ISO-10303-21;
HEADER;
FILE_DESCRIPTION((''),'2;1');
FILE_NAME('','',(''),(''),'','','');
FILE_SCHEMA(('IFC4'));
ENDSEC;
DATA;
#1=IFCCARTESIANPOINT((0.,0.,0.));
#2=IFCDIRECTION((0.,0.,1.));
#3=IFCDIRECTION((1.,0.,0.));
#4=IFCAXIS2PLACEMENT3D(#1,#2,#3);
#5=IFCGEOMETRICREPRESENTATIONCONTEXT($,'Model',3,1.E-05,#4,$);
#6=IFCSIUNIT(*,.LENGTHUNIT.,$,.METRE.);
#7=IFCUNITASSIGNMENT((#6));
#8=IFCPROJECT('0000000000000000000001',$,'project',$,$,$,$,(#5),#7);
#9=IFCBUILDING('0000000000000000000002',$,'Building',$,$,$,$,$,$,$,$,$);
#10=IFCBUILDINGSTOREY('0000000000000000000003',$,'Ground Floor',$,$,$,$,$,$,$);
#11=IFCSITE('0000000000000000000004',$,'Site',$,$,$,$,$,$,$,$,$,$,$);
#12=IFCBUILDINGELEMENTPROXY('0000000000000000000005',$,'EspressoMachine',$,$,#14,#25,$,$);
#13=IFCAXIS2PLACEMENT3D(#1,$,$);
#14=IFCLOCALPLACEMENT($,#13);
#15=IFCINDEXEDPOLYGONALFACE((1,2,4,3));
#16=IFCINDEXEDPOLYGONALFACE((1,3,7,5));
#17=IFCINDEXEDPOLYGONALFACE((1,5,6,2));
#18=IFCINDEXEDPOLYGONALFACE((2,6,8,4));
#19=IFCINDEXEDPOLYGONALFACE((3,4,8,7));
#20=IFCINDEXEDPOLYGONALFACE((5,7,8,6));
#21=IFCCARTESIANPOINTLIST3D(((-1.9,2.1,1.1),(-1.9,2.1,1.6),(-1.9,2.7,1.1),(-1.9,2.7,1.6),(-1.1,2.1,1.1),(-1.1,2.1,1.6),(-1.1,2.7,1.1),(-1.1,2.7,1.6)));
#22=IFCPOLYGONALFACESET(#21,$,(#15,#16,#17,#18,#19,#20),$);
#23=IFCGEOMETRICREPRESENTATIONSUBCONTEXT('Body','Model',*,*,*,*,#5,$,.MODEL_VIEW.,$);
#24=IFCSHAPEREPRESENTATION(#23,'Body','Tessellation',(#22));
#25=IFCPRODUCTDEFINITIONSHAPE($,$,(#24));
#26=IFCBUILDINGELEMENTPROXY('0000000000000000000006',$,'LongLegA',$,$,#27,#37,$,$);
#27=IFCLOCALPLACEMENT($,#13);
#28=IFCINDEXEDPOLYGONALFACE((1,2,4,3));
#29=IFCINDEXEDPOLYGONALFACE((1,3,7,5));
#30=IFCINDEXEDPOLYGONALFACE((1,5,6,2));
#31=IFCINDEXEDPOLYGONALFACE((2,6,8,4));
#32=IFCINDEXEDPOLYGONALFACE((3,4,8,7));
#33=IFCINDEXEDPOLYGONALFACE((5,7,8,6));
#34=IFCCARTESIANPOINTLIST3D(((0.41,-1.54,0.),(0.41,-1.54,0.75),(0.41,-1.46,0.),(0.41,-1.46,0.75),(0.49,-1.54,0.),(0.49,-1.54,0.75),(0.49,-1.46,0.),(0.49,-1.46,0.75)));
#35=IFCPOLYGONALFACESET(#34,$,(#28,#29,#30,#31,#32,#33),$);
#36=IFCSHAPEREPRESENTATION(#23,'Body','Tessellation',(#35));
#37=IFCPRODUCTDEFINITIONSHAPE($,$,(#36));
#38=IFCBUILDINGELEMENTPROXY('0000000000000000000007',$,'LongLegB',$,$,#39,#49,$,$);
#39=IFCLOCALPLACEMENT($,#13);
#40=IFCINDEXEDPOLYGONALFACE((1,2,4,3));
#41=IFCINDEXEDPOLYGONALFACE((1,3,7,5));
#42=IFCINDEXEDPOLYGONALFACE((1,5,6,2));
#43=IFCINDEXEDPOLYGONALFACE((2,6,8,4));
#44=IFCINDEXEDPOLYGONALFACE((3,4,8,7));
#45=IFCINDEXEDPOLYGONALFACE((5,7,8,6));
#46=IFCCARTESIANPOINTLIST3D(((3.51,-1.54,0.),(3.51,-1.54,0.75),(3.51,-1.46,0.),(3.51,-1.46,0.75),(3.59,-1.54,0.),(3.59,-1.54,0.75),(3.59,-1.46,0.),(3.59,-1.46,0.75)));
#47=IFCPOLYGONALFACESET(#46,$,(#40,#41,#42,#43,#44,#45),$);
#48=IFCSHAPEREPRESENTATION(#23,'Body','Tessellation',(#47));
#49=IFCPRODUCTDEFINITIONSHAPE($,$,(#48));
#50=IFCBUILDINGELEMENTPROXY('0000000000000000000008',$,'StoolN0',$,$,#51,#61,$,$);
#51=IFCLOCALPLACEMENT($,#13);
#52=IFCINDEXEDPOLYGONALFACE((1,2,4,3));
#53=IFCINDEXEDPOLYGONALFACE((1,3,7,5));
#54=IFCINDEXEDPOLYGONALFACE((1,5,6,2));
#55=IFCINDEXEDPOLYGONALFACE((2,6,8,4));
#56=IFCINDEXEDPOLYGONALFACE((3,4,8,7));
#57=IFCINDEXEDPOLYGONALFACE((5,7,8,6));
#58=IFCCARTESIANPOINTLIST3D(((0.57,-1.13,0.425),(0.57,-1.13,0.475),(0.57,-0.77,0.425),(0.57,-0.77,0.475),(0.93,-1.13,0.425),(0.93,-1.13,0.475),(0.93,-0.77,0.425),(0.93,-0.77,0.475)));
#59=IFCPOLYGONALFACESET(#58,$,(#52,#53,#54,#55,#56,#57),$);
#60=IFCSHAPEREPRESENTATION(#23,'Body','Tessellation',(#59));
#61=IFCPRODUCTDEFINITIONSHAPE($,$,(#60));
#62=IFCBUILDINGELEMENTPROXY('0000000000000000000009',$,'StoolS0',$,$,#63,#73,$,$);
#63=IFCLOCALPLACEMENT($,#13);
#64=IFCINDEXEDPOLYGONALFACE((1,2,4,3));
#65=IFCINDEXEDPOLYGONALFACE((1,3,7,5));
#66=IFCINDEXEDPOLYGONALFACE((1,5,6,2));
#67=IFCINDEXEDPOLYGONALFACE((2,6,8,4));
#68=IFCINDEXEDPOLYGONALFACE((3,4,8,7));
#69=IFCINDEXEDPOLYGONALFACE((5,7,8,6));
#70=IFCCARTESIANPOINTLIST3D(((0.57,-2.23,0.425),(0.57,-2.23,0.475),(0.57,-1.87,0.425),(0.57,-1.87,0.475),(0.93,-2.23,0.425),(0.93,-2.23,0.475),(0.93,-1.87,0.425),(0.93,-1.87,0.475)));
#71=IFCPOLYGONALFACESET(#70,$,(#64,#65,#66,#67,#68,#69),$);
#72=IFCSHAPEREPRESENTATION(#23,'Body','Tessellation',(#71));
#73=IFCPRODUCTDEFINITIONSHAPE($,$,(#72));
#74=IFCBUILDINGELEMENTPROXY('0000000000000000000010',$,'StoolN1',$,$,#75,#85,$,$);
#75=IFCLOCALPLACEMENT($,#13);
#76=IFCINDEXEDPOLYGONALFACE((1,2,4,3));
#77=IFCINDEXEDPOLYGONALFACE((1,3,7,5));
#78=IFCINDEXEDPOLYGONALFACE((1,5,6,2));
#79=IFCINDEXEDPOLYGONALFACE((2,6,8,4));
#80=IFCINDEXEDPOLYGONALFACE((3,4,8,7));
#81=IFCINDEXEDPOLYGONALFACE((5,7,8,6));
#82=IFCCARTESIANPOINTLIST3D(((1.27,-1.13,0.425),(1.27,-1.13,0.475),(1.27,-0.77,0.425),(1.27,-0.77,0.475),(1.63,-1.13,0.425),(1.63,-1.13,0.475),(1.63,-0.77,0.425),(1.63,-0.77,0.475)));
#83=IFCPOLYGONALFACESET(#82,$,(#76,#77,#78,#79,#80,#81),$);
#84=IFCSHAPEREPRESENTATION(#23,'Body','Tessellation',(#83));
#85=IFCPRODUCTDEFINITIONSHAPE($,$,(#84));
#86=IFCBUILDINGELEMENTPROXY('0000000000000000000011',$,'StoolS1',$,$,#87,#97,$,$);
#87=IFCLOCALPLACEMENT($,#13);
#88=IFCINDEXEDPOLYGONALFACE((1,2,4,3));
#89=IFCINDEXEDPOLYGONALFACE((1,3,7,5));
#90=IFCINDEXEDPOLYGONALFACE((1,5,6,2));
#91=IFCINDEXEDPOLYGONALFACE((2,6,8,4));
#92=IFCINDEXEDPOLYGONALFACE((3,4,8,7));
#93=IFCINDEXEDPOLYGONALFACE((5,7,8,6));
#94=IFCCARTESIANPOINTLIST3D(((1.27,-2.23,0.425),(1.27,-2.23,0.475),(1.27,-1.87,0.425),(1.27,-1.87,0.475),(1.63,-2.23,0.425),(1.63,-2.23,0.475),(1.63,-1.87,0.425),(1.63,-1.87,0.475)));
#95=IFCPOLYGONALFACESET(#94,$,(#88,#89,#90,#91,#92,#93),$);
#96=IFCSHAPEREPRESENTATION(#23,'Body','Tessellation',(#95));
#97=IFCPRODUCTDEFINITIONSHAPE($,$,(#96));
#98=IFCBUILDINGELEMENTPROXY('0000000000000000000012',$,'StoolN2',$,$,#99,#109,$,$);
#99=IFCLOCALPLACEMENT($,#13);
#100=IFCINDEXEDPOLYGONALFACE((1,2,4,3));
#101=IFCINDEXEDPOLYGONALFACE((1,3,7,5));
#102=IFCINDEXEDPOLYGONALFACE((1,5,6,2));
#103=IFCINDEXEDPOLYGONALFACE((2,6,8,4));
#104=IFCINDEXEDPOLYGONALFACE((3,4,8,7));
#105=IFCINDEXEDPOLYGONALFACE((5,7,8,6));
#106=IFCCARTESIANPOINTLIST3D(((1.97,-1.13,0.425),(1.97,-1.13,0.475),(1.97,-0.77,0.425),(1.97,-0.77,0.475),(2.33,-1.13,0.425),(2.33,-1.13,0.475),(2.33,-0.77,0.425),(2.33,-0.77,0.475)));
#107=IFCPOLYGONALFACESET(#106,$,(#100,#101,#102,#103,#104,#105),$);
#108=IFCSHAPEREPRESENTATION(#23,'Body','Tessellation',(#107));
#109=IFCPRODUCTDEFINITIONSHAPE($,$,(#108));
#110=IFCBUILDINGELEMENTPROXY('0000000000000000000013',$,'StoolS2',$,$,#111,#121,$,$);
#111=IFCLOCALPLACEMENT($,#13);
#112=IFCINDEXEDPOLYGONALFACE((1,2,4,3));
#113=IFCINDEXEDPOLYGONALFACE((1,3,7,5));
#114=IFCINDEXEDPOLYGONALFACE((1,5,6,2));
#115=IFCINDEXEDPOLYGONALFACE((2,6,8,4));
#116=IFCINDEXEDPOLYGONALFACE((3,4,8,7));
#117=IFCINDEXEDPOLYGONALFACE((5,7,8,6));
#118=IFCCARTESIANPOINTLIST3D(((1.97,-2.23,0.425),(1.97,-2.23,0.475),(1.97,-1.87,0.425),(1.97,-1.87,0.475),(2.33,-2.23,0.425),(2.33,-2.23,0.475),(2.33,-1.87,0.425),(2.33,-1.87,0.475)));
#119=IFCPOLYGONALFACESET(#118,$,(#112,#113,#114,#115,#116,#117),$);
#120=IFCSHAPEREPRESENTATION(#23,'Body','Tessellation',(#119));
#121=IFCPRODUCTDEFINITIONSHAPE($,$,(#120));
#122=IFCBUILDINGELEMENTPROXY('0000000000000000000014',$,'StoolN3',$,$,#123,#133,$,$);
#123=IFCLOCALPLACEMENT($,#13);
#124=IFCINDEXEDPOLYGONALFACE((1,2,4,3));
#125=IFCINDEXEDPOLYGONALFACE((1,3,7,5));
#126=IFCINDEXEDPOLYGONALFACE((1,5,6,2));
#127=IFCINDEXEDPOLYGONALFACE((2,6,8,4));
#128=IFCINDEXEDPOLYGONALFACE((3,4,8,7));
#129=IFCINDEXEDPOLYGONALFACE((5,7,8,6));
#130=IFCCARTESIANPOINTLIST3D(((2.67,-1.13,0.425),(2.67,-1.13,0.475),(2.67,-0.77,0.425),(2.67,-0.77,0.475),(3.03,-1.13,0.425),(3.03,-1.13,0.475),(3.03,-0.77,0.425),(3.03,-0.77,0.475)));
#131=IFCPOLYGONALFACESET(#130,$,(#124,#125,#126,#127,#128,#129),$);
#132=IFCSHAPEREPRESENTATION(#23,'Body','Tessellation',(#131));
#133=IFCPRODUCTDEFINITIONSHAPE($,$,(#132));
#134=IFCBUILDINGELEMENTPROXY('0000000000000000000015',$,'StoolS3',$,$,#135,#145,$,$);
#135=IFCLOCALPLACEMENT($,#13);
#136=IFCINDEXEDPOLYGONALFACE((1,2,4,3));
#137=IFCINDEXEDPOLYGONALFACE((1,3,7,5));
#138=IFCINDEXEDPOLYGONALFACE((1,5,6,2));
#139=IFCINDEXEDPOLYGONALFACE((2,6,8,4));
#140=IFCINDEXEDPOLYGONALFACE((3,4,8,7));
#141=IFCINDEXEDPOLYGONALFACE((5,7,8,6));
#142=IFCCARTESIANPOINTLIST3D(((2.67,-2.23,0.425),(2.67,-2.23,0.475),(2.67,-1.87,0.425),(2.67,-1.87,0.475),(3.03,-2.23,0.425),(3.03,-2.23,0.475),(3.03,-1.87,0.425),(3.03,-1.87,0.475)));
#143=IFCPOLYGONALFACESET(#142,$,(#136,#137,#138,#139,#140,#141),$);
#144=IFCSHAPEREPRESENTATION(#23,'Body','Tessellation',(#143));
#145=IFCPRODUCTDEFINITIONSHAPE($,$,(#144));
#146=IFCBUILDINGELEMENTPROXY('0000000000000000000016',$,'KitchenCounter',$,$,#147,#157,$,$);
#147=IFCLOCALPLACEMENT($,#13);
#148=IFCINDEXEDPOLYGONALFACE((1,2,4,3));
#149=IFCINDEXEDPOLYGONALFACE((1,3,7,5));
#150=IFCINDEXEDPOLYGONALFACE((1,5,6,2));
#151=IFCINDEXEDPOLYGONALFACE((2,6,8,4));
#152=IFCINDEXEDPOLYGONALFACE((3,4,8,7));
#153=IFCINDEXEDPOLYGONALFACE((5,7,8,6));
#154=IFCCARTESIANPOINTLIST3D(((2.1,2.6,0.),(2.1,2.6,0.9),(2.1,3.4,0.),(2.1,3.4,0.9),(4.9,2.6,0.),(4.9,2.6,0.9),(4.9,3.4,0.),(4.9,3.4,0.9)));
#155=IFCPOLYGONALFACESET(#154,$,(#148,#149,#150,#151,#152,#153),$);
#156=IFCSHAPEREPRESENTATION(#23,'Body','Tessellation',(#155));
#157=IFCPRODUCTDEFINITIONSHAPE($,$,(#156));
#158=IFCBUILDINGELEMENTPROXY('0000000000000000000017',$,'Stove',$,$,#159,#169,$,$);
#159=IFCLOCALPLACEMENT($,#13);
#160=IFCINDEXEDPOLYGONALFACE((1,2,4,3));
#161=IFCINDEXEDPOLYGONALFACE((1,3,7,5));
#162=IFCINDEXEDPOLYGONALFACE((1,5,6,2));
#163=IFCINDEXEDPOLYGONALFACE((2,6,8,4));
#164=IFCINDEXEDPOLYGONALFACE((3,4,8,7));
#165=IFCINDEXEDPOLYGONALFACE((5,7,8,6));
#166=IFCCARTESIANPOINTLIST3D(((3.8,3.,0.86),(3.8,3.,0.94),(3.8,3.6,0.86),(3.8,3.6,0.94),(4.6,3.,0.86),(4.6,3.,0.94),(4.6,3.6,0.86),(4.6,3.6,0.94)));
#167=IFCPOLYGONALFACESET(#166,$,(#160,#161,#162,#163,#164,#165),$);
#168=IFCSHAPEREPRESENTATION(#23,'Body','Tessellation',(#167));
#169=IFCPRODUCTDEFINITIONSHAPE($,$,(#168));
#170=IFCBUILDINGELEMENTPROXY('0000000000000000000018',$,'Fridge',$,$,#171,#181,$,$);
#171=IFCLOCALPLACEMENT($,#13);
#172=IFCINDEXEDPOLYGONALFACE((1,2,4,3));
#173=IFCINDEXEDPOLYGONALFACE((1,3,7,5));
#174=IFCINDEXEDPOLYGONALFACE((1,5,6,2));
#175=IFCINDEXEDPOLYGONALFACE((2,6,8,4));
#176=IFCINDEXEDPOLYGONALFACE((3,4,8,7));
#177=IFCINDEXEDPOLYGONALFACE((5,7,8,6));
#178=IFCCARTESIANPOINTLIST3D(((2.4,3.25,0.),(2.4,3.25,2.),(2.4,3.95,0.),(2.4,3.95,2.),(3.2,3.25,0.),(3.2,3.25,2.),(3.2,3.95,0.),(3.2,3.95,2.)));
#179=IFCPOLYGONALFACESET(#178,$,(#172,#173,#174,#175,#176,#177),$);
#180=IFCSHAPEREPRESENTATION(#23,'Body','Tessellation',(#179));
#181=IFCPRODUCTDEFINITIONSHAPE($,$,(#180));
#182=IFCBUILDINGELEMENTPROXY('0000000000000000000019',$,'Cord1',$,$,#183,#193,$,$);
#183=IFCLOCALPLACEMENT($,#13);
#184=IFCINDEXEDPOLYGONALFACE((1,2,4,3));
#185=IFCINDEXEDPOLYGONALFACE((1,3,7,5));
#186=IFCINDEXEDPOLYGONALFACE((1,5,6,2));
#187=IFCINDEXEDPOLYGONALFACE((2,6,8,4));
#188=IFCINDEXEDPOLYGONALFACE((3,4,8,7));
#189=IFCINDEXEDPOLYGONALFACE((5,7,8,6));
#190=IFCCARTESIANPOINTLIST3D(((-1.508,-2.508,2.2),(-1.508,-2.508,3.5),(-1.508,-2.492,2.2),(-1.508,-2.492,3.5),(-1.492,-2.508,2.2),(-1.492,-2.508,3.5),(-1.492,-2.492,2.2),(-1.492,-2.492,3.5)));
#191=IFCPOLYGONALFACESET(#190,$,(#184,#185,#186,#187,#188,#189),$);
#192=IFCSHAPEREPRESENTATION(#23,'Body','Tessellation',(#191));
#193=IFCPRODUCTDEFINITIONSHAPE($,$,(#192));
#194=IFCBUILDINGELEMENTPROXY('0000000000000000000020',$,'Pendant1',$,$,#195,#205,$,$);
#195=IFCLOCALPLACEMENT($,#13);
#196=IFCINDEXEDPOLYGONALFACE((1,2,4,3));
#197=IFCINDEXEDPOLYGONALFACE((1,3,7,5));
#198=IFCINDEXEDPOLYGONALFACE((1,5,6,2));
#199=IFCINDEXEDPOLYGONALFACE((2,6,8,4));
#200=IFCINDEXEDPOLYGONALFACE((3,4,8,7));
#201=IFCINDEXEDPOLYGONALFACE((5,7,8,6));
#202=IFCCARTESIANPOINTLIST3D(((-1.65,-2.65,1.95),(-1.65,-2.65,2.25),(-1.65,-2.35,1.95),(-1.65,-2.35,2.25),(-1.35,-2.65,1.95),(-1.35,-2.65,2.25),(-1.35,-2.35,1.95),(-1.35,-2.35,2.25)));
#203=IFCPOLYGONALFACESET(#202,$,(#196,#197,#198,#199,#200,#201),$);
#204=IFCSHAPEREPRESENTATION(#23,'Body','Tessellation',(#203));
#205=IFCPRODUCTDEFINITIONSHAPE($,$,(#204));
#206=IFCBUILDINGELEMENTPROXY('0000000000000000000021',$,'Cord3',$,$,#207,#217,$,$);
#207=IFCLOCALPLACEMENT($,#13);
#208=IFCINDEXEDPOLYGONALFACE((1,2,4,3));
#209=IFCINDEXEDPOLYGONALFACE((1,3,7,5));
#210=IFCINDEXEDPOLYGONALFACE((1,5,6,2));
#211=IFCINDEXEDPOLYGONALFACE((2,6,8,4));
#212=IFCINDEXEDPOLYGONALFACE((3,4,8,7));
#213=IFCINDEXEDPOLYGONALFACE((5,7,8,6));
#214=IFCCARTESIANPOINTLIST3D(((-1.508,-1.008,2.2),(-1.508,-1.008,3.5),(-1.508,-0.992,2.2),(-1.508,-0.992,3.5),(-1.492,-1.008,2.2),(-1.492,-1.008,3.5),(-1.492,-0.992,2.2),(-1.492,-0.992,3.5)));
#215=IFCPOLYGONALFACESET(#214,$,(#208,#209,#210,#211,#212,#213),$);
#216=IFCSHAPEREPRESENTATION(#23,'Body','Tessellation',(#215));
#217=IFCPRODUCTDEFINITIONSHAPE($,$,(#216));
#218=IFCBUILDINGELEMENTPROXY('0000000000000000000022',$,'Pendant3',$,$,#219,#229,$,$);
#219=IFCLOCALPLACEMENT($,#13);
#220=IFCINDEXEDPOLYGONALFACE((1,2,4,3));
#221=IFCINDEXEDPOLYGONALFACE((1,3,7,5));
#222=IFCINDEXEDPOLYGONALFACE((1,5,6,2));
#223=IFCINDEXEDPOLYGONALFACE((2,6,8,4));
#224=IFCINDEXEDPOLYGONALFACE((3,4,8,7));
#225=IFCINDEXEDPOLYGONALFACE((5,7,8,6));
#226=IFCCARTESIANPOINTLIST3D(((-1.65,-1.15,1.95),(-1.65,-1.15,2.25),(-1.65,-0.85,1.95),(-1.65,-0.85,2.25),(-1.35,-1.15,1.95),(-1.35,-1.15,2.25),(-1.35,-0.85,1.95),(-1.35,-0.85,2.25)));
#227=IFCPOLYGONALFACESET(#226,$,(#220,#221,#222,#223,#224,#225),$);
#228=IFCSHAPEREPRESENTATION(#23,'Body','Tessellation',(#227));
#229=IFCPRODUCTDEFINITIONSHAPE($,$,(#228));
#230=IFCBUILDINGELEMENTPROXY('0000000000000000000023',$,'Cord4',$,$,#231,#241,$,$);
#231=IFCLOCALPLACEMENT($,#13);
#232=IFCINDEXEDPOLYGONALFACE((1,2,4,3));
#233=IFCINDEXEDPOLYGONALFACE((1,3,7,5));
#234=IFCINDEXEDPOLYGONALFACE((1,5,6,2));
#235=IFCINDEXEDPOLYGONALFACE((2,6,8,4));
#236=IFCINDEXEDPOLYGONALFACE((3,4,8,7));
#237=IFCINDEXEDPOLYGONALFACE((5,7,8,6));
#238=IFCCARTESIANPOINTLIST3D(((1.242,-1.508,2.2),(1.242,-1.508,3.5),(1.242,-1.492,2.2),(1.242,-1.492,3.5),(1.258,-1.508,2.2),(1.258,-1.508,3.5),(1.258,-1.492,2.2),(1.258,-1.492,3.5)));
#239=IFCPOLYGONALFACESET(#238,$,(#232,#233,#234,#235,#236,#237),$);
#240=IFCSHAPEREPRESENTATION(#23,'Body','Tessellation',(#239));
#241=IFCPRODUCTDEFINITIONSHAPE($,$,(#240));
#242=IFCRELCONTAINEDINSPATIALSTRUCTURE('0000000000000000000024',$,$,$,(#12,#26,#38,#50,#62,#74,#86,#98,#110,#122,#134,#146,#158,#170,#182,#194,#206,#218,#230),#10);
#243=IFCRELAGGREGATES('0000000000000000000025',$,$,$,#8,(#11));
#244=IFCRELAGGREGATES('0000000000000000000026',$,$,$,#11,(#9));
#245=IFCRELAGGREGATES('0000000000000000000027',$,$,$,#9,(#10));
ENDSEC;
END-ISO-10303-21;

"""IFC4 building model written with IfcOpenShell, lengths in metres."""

from ifc_helpers import new_model, si_unit, frame, origin_with_axes, origin_2d, place, context, subcontext, project, spatial, rectangle, extrude, element, save


model = new_model("IFC4")

# Units and contexts
model_context = context("Model", 3, precision=1e-05, world=origin_with_axes())
body_context = subcontext(model_context, "Body", "Model", "MODEL_VIEW")
ifc_project = project(units=[si_unit("LENGTHUNIT", "METRE")], contexts=[model_context])

# Site, building, storey
site = spatial("IfcSite", under=ifc_project, Name="Site")
building = spatial("IfcBuilding", under=site, Name="Building")
storey = spatial("IfcBuildingStorey", under=building, Name="Ground Floor")

# Building element proxies
proxy_1_placement = place(None, frame((-1.5, 2.4, 1.35), z_axis=(0.0, 0.0, 1.0), x_axis=(1.0, 0.0, 0.0)))
element("IfcBuildingElementProxy", 1, at=proxy_1_placement, inside=storey, Name="EspressoMachine", context=body_context, shape_type="SweptSolid", body=[
    extrude(rectangle(XDim=0.8, YDim=0.6, at=origin_2d()), frame((0.0, 0.0, -0.25)), (0.0, 0.0, 1.0), 0.5),
])
for number, where, z_axis, x_axis, name in (
    (2, (0.45, -1.5, 0.375), (0.0, 0.0, 1.0), (1.0, 0.0, 0.0), "LongLegA"),
    (3, (3.55, -1.5, 0.375), (0.0, 0.0, 1.0), (1.0, 0.0, 0.0), "LongLegB"),
):
    element("IfcBuildingElementProxy", number, at=place(None, frame(where, z_axis=z_axis, x_axis=x_axis)), inside=storey, Name=name, context=body_context, shape_type="SweptSolid", body=[
        extrude(rectangle(XDim=0.08, YDim=0.08, at=origin_2d()), frame((0.0, 0.0, -0.375)), (0.0, 0.0, 1.0), 0.75),
    ])
for number, where, z_axis, x_axis, name in (
    (4, (0.75, -0.95, 0.45), (0.0, 0.0, 1.0), (1.0, 0.0, 0.0), "StoolN0"),
    (5, (0.75, -2.05, 0.45), (0.0, 0.0, 1.0), (1.0, 0.0, 0.0), "StoolS0"),
    (6, (1.45, -0.95, 0.45), (0.0, 0.0, 1.0), (1.0, 0.0, 0.0), "StoolN1"),
    (7, (1.45, -2.05, 0.45), (0.0, 0.0, 1.0), (1.0, 0.0, 0.0), "StoolS1"),
    (8, (2.15, -0.95, 0.45), (0.0, 0.0, 1.0), (1.0, 0.0, 0.0), "StoolN2"),
    (9, (2.15, -2.05, 0.45), (0.0, 0.0, 1.0), (1.0, 0.0, 0.0), "StoolS2"),
    (10, (2.85, -0.95, 0.45), (0.0, 0.0, 1.0), (1.0, 0.0, 0.0), "StoolN3"),
    (11, (2.85, -2.05, 0.45), (0.0, 0.0, 1.0), (1.0, 0.0, 0.0), "StoolS3"),
):
    element("IfcBuildingElementProxy", number, at=place(None, frame(where, z_axis=z_axis, x_axis=x_axis)), inside=storey, Name=name, context=body_context, shape_type="SweptSolid", body=[
        extrude(rectangle(XDim=0.36, YDim=0.36, at=origin_2d()), frame((0.0, 0.0, -0.025)), (0.0, 0.0, 1.0), 0.05),
    ])
proxy_2_placement = place(None, frame((3.5, 3.0, 0.45), z_axis=(0.0, 0.0, 1.0), x_axis=(1.0, 0.0, 0.0)))
element("IfcBuildingElementProxy", 12, at=proxy_2_placement, inside=storey, Name="KitchenCounter", context=body_context, shape_type="SweptSolid", body=[
    extrude(rectangle(XDim=2.8, YDim=0.8, at=origin_2d()), frame((0.0, 0.0, -0.45)), (0.0, 0.0, 1.0), 0.9),
])
proxy_3_placement = place(None, frame((4.2, 3.3, 0.9), z_axis=(0.0, 0.0, 1.0), x_axis=(1.0, 0.0, 0.0)))
element("IfcBuildingElementProxy", 13, at=proxy_3_placement, inside=storey, Name="Stove", context=body_context, shape_type="SweptSolid", body=[
    extrude(rectangle(XDim=0.8, YDim=0.6, at=origin_2d()), frame((0.0, 0.0, -0.04)), (0.0, 0.0, 1.0), 0.08),
])
proxy_4_placement = place(None, frame((2.8, 3.6, 1.0), z_axis=(0.0, 0.0, 1.0), x_axis=(1.0, 0.0, 0.0)))
element("IfcBuildingElementProxy", 14, at=proxy_4_placement, inside=storey, Name="Fridge", context=body_context, shape_type="SweptSolid", body=[
    extrude(rectangle(XDim=0.8, YDim=0.7, at=origin_2d()), frame((0.0, 0.0, -1.0)), (0.0, 0.0, 1.0), 2.0),
])
proxy_5_placement = place(None, frame((-1.5, -2.5, 2.85), z_axis=(0.0, 0.0, 1.0), x_axis=(1.0, 0.0, 0.0)))
element("IfcBuildingElementProxy", 15, at=proxy_5_placement, inside=storey, Name="Cord1", context=body_context, shape_type="SweptSolid", body=[
    extrude(rectangle(XDim=0.016, YDim=0.016, at=origin_2d()), frame((0.0, 0.0, -0.65)), (0.0, 0.0, 1.0), 1.3),
])
proxy_6_placement = place(None, frame((-1.5, -2.5, 2.1), z_axis=(0.0, 0.0, 1.0), x_axis=(1.0, 0.0, 0.0)))
element("IfcBuildingElementProxy", 16, at=proxy_6_placement, inside=storey, Name="Pendant1", context=body_context, shape_type="SweptSolid", body=[
    extrude(rectangle(XDim=0.3, YDim=0.3, at=origin_2d()), frame((0.0, 0.0, -0.15)), (0.0, 0.0, 1.0), 0.3),
])
proxy_7_placement = place(None, frame((-1.5, -1.0, 2.85), z_axis=(0.0, 0.0, 1.0), x_axis=(1.0, 0.0, 0.0)))
element("IfcBuildingElementProxy", 17, at=proxy_7_placement, inside=storey, Name="Cord3", context=body_context, shape_type="SweptSolid", body=[
    extrude(rectangle(XDim=0.016, YDim=0.016, at=origin_2d()), frame((0.0, 0.0, -0.65)), (0.0, 0.0, 1.0), 1.3),
])
proxy_8_placement = place(None, frame((-1.5, -1.0, 2.1), z_axis=(0.0, 0.0, 1.0), x_axis=(1.0, 0.0, 0.0)))
element("IfcBuildingElementProxy", 18, at=proxy_8_placement, inside=storey, Name="Pendant3", context=body_context, shape_type="SweptSolid", body=[
    extrude(rectangle(XDim=0.3, YDim=0.3, at=origin_2d()), frame((0.0, 0.0, -0.15)), (0.0, 0.0, 1.0), 0.3),
])
proxy_9_placement = place(None, frame((1.25, -1.5, 2.85), z_axis=(0.0, 0.0, 1.0), x_axis=(1.0, 0.0, 0.0)))
element("IfcBuildingElementProxy", 19, at=proxy_9_placement, inside=storey, Name="Cord4", context=body_context, shape_type="SweptSolid", body=[
    extrude(rectangle(XDim=0.016, YDim=0.016, at=origin_2d()), frame((0.0, 0.0, -0.65)), (0.0, 0.0, 1.0), 1.3),
])

save(model, "model.ifc")
